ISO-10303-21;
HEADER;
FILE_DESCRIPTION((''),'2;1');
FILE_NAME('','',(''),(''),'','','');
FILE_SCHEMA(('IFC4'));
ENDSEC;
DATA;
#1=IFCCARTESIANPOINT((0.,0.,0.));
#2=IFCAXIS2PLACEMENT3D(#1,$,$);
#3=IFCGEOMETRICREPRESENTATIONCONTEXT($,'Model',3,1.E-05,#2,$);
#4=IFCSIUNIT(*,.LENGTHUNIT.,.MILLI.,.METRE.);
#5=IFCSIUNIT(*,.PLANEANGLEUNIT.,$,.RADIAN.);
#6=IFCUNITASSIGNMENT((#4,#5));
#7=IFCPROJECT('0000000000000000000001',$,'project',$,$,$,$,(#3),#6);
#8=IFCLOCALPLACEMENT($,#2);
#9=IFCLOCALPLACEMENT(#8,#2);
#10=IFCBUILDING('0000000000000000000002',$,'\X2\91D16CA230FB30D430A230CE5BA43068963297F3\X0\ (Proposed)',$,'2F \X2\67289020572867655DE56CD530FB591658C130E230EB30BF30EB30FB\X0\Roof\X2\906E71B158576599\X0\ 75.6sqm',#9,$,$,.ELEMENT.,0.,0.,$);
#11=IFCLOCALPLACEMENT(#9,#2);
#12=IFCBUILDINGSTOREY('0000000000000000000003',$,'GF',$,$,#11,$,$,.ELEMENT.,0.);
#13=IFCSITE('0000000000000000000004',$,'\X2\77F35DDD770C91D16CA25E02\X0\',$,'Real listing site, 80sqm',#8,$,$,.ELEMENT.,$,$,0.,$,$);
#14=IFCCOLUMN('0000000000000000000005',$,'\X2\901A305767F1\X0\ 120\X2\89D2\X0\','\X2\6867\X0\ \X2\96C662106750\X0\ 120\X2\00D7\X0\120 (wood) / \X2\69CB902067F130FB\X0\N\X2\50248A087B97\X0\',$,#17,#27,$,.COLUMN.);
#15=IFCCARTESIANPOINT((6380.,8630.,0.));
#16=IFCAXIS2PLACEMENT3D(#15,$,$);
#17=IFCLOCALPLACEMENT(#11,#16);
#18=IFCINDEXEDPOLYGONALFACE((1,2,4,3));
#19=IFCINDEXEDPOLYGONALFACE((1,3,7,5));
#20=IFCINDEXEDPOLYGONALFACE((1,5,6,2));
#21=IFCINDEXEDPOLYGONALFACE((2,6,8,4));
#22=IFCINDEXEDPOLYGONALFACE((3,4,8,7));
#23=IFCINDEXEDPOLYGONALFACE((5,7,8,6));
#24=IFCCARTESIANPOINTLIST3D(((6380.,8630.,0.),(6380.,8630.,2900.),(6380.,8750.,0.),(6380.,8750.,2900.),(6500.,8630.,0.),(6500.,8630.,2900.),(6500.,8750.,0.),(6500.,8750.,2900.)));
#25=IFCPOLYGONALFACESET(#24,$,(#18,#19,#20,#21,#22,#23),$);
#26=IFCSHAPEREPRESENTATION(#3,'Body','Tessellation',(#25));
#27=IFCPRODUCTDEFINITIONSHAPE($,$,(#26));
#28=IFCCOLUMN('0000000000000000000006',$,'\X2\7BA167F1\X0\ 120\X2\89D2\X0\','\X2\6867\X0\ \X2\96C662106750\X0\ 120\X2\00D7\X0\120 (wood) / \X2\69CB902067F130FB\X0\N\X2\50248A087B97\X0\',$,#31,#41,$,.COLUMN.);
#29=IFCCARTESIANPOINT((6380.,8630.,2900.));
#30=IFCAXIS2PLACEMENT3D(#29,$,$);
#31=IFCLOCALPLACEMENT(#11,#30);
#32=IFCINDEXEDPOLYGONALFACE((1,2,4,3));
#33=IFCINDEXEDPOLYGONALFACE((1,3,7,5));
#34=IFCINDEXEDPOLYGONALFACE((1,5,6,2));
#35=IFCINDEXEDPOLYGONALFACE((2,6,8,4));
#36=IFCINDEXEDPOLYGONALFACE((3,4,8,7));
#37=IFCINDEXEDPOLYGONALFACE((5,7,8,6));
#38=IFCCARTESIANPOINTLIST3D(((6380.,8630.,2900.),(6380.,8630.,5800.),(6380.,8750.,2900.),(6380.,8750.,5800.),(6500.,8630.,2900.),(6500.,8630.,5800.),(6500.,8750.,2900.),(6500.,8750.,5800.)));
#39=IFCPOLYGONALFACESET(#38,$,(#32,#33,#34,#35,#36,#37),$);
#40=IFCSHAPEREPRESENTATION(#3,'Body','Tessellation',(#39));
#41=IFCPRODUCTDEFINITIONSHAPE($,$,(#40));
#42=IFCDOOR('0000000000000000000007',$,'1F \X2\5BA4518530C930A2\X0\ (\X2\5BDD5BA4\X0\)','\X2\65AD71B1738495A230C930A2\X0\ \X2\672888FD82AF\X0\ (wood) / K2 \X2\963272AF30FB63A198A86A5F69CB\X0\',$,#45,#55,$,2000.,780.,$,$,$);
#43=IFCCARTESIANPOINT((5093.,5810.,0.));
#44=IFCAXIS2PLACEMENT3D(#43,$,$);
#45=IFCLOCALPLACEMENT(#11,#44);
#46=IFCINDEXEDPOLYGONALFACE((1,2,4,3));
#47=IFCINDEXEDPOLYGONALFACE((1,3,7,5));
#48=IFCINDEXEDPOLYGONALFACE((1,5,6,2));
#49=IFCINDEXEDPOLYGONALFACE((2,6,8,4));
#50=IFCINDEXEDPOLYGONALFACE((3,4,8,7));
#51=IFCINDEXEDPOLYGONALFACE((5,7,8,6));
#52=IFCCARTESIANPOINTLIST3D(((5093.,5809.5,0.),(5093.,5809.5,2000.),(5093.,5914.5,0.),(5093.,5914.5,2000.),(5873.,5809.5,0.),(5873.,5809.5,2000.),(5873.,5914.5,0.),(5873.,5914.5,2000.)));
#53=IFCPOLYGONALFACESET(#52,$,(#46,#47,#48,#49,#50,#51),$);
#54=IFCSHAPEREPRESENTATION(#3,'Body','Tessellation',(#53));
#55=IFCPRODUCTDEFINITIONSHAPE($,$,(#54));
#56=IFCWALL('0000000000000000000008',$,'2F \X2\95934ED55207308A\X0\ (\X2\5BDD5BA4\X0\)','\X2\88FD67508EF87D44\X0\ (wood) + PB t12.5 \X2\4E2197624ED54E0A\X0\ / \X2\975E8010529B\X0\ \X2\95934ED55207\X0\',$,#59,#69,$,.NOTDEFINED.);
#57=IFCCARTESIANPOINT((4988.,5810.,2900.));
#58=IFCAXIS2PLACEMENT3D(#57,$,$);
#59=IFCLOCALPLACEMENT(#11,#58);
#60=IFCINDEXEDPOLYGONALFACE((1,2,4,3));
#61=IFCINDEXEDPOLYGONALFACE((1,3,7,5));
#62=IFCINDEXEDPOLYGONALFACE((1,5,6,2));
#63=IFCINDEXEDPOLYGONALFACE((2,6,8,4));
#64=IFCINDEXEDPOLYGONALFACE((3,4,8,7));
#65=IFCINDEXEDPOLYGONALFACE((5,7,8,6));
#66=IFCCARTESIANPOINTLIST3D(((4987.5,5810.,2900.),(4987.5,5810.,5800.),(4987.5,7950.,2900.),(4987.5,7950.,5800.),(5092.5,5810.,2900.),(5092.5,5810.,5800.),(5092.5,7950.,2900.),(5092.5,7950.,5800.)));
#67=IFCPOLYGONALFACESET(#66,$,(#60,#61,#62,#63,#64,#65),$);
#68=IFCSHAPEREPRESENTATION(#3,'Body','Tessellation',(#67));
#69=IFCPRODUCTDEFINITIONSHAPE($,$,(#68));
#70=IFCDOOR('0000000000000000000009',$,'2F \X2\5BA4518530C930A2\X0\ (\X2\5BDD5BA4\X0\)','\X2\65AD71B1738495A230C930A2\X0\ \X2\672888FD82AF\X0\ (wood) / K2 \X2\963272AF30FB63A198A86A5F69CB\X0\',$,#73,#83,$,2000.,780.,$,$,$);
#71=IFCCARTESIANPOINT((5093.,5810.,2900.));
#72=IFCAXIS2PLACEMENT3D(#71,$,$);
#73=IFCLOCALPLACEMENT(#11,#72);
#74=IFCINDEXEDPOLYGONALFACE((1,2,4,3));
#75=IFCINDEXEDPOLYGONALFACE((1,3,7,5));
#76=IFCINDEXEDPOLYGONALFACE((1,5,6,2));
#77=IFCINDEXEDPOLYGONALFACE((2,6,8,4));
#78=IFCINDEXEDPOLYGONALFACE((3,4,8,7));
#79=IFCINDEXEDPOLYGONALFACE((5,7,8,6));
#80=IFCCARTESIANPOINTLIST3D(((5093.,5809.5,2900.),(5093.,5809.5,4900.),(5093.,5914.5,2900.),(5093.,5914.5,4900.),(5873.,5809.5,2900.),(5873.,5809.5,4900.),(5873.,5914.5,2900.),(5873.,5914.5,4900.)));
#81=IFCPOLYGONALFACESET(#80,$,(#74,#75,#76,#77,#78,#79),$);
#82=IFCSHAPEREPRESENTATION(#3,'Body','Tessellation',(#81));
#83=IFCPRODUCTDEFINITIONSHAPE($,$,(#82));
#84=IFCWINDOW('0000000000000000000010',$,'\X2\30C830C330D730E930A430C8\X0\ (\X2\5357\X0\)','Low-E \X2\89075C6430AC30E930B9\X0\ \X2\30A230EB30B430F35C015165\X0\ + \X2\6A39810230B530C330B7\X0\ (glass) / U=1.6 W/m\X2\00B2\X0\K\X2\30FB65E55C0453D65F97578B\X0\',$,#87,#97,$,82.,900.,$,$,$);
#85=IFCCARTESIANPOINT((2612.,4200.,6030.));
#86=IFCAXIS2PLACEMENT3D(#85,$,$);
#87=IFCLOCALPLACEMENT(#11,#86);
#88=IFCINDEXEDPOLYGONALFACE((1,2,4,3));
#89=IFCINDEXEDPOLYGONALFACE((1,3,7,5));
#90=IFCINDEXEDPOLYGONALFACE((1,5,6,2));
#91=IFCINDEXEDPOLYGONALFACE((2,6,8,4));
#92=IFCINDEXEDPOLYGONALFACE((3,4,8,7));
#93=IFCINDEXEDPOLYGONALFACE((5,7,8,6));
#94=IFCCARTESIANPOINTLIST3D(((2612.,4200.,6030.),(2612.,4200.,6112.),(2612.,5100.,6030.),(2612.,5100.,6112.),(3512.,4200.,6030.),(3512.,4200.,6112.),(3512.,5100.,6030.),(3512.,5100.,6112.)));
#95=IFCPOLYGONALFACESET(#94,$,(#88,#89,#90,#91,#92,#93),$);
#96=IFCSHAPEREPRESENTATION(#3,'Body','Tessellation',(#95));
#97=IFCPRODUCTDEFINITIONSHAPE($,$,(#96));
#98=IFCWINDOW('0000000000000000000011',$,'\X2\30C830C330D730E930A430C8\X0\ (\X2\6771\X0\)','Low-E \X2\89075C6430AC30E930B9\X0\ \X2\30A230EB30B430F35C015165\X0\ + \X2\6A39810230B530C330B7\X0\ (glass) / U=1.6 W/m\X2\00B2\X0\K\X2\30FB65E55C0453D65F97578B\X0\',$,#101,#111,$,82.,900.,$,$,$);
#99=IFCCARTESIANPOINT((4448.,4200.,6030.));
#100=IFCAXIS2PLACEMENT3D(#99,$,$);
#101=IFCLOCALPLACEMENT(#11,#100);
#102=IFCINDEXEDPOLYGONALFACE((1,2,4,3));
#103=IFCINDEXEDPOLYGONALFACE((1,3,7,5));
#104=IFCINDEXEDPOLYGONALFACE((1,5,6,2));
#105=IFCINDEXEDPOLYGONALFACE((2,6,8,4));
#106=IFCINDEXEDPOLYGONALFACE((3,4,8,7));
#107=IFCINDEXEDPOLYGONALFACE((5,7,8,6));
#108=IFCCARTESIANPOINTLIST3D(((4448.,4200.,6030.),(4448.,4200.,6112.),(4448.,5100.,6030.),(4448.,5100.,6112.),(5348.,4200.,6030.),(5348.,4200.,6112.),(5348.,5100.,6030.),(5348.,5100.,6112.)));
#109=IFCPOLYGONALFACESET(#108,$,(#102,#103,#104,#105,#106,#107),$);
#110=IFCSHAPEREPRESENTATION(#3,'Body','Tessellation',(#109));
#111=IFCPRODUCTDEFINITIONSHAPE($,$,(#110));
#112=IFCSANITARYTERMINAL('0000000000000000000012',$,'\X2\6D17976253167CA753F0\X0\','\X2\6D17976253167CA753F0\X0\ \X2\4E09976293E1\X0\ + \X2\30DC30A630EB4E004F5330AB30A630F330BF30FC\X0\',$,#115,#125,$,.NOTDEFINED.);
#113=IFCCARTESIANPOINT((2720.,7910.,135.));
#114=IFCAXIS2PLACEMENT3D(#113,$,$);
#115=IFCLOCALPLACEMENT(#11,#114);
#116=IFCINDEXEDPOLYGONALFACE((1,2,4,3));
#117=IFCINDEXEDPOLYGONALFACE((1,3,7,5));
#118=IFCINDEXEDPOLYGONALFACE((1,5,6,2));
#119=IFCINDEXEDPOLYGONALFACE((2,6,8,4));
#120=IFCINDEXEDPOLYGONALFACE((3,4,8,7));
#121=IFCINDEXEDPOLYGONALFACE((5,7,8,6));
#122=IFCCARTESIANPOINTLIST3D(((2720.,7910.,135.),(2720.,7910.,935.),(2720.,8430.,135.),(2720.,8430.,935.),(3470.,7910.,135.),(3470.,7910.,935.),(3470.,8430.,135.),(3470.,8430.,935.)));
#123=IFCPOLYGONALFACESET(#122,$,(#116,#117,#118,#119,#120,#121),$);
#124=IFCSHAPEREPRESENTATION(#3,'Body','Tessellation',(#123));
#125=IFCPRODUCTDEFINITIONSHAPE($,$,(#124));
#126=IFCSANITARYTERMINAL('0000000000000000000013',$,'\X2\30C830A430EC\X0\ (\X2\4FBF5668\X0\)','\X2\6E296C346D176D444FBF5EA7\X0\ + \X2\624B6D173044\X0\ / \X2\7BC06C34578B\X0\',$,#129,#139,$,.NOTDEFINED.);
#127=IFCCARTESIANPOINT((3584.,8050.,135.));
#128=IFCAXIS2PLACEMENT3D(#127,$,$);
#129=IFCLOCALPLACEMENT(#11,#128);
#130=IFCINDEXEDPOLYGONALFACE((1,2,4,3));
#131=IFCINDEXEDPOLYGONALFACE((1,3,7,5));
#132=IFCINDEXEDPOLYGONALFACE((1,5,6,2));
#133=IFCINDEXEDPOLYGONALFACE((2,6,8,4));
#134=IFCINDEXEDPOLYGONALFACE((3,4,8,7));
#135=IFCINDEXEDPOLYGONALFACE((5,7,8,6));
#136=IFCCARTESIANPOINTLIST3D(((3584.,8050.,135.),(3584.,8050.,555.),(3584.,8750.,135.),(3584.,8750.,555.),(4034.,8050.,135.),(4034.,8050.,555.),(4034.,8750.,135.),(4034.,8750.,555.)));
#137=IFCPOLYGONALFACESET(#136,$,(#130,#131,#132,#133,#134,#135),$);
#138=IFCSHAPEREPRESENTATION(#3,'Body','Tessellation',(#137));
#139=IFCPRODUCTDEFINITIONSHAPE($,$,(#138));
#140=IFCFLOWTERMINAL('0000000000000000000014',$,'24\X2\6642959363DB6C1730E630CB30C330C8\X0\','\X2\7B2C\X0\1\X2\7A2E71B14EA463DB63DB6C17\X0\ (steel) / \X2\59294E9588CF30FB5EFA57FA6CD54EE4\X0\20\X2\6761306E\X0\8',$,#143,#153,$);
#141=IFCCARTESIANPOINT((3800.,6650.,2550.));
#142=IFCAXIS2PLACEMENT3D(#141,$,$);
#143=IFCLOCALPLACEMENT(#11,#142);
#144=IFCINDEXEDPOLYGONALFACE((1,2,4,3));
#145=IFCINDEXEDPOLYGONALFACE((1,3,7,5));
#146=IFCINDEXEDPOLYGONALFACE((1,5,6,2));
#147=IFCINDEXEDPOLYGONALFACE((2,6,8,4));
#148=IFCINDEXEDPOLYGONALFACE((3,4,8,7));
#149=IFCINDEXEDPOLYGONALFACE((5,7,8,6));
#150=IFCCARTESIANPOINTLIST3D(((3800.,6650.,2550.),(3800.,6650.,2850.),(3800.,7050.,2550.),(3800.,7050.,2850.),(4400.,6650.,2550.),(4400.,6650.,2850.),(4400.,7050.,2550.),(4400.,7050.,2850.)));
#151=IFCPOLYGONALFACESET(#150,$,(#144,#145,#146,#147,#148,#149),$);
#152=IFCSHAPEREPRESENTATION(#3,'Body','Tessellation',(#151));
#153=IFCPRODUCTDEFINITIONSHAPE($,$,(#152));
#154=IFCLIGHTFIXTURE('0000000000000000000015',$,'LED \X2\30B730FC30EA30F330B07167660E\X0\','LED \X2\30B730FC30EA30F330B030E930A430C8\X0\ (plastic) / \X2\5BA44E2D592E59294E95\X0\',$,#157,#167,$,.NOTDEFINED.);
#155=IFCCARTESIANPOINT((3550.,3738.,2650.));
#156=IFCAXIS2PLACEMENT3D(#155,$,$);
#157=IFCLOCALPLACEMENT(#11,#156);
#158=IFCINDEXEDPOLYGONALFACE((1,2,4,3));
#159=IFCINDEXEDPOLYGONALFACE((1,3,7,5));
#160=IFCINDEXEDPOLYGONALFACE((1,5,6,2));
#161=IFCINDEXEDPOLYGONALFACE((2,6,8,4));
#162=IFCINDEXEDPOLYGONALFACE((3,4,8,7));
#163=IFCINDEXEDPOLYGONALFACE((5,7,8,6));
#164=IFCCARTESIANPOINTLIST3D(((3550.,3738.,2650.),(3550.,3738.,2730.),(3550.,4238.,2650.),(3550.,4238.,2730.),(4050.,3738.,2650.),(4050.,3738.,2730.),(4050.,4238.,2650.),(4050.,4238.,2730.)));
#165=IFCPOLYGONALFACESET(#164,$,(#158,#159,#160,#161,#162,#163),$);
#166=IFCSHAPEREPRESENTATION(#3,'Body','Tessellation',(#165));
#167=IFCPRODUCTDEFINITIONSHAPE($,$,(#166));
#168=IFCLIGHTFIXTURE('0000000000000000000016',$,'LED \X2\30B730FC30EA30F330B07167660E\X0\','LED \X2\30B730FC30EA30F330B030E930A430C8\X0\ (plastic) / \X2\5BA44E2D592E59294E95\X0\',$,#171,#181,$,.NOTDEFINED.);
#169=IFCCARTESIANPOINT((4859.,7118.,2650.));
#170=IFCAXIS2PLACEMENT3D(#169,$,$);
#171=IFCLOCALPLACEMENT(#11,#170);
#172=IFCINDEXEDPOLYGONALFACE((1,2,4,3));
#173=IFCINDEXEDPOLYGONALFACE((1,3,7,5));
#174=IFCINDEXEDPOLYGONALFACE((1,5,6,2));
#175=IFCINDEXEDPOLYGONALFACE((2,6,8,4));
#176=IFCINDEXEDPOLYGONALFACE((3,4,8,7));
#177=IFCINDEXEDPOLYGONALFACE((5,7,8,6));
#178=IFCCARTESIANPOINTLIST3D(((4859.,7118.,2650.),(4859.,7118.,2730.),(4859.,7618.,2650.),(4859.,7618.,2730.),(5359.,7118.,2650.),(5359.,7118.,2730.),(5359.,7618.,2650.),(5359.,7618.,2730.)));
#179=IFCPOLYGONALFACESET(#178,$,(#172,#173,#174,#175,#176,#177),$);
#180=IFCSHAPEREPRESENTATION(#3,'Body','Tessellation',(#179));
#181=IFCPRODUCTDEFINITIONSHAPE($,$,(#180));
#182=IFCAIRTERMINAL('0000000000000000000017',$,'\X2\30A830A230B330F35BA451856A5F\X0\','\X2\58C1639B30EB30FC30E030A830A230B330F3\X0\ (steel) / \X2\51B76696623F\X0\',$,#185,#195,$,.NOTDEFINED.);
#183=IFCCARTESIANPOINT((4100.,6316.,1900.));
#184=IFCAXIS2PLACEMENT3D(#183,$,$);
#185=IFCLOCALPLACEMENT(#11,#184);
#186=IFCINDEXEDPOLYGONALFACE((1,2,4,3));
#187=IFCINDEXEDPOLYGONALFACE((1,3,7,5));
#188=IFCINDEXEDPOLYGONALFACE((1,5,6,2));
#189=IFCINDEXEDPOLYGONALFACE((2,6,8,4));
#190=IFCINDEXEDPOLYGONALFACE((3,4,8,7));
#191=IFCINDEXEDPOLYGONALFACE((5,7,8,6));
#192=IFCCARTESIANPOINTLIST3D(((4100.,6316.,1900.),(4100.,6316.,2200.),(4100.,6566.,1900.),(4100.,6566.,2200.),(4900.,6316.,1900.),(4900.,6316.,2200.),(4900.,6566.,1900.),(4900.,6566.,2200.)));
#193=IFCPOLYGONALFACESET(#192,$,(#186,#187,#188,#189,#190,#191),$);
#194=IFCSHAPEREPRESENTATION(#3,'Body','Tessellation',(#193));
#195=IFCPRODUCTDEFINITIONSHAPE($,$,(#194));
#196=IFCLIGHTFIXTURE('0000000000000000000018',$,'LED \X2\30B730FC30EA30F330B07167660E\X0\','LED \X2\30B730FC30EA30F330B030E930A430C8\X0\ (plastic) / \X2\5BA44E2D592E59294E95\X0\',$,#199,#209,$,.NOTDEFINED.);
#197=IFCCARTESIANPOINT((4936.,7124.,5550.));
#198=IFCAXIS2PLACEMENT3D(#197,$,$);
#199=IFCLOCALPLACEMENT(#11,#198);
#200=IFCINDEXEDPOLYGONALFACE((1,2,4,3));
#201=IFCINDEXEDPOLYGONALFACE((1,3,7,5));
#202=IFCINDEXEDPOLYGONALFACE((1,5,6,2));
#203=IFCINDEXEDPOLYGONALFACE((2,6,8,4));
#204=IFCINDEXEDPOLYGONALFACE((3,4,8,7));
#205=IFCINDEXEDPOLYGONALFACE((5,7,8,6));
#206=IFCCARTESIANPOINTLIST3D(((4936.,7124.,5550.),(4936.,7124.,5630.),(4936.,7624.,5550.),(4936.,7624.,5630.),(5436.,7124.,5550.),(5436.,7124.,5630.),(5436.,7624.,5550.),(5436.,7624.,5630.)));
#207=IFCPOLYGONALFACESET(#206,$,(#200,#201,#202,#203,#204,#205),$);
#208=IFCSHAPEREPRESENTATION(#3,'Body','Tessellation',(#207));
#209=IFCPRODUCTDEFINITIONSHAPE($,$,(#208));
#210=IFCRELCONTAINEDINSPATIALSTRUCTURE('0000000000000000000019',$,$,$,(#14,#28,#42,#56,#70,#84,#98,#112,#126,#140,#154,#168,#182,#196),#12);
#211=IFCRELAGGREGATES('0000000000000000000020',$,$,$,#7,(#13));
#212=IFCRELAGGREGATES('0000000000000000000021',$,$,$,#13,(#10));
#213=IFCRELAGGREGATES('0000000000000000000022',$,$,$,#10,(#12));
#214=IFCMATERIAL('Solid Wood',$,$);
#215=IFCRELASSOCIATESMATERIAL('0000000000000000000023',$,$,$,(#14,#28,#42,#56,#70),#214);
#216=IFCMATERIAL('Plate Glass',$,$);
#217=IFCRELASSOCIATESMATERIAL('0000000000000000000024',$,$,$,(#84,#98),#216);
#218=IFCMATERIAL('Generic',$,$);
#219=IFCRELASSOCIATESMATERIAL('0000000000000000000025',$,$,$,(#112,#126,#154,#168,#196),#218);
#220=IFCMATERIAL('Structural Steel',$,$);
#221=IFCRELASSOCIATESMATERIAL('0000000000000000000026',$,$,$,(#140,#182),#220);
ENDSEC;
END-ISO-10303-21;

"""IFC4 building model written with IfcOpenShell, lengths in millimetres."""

from ifc_helpers import new_model, si_unit, frame, frame_2d, origin, place, context, project, spatial, rectangle, extrude, material, element, save


model = new_model("IFC4")

# Units and contexts
model_context = context("Model", 3, precision=1e-05, world=origin())
ifc_project = project(units=[si_unit("LENGTHUNIT", "METRE", prefix="MILLI"), si_unit("PLANEANGLEUNIT", "RADIAN")], contexts=[model_context])

# Site, building, storey
site_placement = place(None, origin())
site = spatial("IfcSite", under=ifc_project, at=site_placement, Name="石川県金沢市", ObjectType="Real listing site, 80sqm", CompositionType="ELEMENT", RefElevation=0.0)
building_placement = place(site_placement, origin())
building = spatial("IfcBuilding", under=site, at=building_placement, Name="金沢・ピアノ室と防音 (Proposed)", ObjectType="2F 木造在来工法・外壁モルタル・Roof遮熱塗料 75.6sqm", CompositionType="ELEMENT", ElevationOfRefHeight=0.0, ElevationOfTerrain=0.0)
storey_placement = place(building_placement, origin())
storey = spatial("IfcBuildingStorey", under=building, at=storey_placement, Name="GF", CompositionType="ELEMENT", Elevation=0.0)

# Columns
ifc_material_1 = material(Name="Solid Wood")
column_1_placement = place(storey_placement, frame((6380.0, 8630.0, 0.0)))
element("IfcColumn", 1, at=column_1_placement, inside=storey, material=ifc_material_1, Name="通し柱 120角", Description="桧 集成材 120×120 (wood) / 構造柱・N値計算", PredefinedType="COLUMN", context=model_context, shape_type="SweptSolid", body=[
    extrude(rectangle(XDim=120.0, YDim=120.0, at=frame_2d((60.0, 60.0))), frame((6380.0, 8630.0, 0.0)), (0.0, 0.0, 1.0), 2900.0),
])
column_2_placement = place(storey_placement, frame((6380.0, 8630.0, 2900.0)))
element("IfcColumn", 2, at=column_2_placement, inside=storey, material=ifc_material_1, Name="管柱 120角", Description="桧 集成材 120×120 (wood) / 構造柱・N値計算", PredefinedType="COLUMN", context=model_context, shape_type="SweptSolid", body=[
    extrude(rectangle(XDim=120.0, YDim=120.0, at=frame_2d((60.0, 60.0))), frame((6380.0, 8630.0, 2900.0)), (0.0, 0.0, 1.0), 2900.0),
])

# Door
door_1_placement = place(storey_placement, frame((5093.0, 5810.0, 0.0)))
element("IfcDoor", 3, at=door_1_placement, inside=storey, material=ifc_material_1, Name="1F 室内ドア (寝室)", Description="断熱玄関ドア 木製芯 (wood) / K2 防犯・採風機構", OverallHeight=2000.0, OverallWidth=780.0, context=model_context, shape_type="SweptSolid", body=[
    extrude(rectangle(XDim=780.0, YDim=105.0, at=frame_2d((390.0, 52.0))), frame((5093.0, 5810.0, 0.0)), (0.0, 0.0, 1.0), 2000.0),
])

# Wall
wall_1_placement = place(storey_placement, frame((4988.0, 5810.0, 2900.0)))
element("IfcWall", 4, at=wall_1_placement, inside=storey, material=ifc_material_1, Name="2F 間仕切り (寝室)", Description="製材軸組 (wood) + PB t12.5 両面仕上 / 非耐力 間仕切", PredefinedType="NOTDEFINED", context=model_context, shape_type="SweptSolid", body=[
    extrude(rectangle(XDim=105.0, YDim=2140.0, at=frame_2d((52.0, 1070.0))), frame((4988.0, 5810.0, 2900.0)), (0.0, 0.0, 1.0), 2900.0),
])

# Door
door_2_placement = place(storey_placement, frame((5093.0, 5810.0, 2900.0)))
element("IfcDoor", 5, at=door_2_placement, inside=storey, material=ifc_material_1, Name="2F 室内ドア (寝室)", Description="断熱玄関ドア 木製芯 (wood) / K2 防犯・採風機構", OverallHeight=2000.0, OverallWidth=780.0, context=model_context, shape_type="SweptSolid", body=[
    extrude(rectangle(XDim=780.0, YDim=105.0, at=frame_2d((390.0, 52.0))), frame((5093.0, 5810.0, 2900.0)), (0.0, 0.0, 1.0), 2000.0),
])

# Windows
ifc_material_2 = material(Name="Plate Glass")
window_1_placement = place(storey_placement, frame((2612.0, 4200.0, 6030.0)))
element("IfcWindow", 6, at=window_1_placement, inside=storey, material=ifc_material_2, Name="トップライト (南)", Description="Low-E 複層ガラス アルゴン封入 + 樹脂サッシ (glass) / U=1.6 W/m²K・日射取得型", OverallHeight=82.0, OverallWidth=900.0, context=model_context, shape_type="SweptSolid", body=[
    extrude(rectangle(XDim=900.0, YDim=900.0, at=frame_2d((450.0, 450.0))), frame((2612.0, 4200.0, 6030.0)), (0.0, 0.0, 1.0), 82.0),
])
window_2_placement = place(storey_placement, frame((4448.0, 4200.0, 6030.0)))
element("IfcWindow", 7, at=window_2_placement, inside=storey, material=ifc_material_2, Name="トップライト (東)", Description="Low-E 複層ガラス アルゴン封入 + 樹脂サッシ (glass) / U=1.6 W/m²K・日射取得型", OverallHeight=82.0, OverallWidth=900.0, context=model_context, shape_type="SweptSolid", body=[
    extrude(rectangle(XDim=900.0, YDim=900.0, at=frame_2d((450.0, 450.0))), frame((4448.0, 4200.0, 6030.0)), (0.0, 0.0, 1.0), 82.0),
])

# Sanitary terminals
ifc_material_3 = material(Name="Generic")
sanitary_terminal_1_placement = place(storey_placement, frame((2720.0, 7910.0, 135.0)))
element("IfcSanitaryTerminal", 8, at=sanitary_terminal_1_placement, inside=storey, material=ifc_material_3, Name="洗面化粧台", Description="洗面化粧台 三面鏡 + ボウル一体カウンター", PredefinedType="NOTDEFINED", context=model_context, shape_type="SweptSolid", body=[
    extrude(rectangle(XDim=750.0, YDim=520.0, at=frame_2d((375.0, 260.0))), frame((2720.0, 7910.0, 135.0)), (0.0, 0.0, 1.0), 800.0),
])
sanitary_terminal_2_placement = place(storey_placement, frame((3584.0, 8050.0, 135.0)))
element("IfcSanitaryTerminal", 9, at=sanitary_terminal_2_placement, inside=storey, material=ifc_material_3, Name="トイレ (便器)", Description="温水洗浄便座 + 手洗い / 節水型", PredefinedType="NOTDEFINED", context=model_context, shape_type="SweptSolid", body=[
    extrude(rectangle(XDim=450.0, YDim=700.0, at=frame_2d((225.0, 350.0))), frame((3584.0, 8050.0, 135.0)), (0.0, 0.0, 1.0), 420.0),
])

# Flow terminal
ifc_material_4 = material(Name="Structural Steel")
flow_terminal_placement = place(storey_placement, frame((3800.0, 6650.0, 2550.0)))
element("IfcFlowTerminal", 10, at=flow_terminal_placement, inside=storey, material=ifc_material_4, Name="24時間換気ユニット", Description="第1種熱交換換気 (steel) / 天井裏・建基法令20条の8", context=model_context, shape_type="SweptSolid", body=[
    extrude(rectangle(XDim=600.0, YDim=400.0, at=frame_2d((300.0, 200.0))), frame((3800.0, 6650.0, 2550.0)), (0.0, 0.0, 1.0), 300.0),
])

# Light fixtures
light_fixture_1_placement = place(storey_placement, frame((3550.0, 3738.0, 2650.0)))
element("IfcLightFixture", 11, at=light_fixture_1_placement, inside=storey, material=ifc_material_3, Name="LED シーリング照明", Description="LED シーリングライト (plastic) / 室中央天井", PredefinedType="NOTDEFINED", context=model_context, shape_type="SweptSolid", body=[
    extrude(rectangle(XDim=500.0, YDim=500.0, at=frame_2d((250.0, 250.0))), frame((3550.0, 3738.0, 2650.0)), (0.0, 0.0, 1.0), 80.0),
])
light_fixture_2_placement = place(storey_placement, frame((4859.0, 7118.0, 2650.0)))
element("IfcLightFixture", 12, at=light_fixture_2_placement, inside=storey, material=ifc_material_3, Name="LED シーリング照明", Description="LED シーリングライト (plastic) / 室中央天井", PredefinedType="NOTDEFINED", context=model_context, shape_type="SweptSolid", body=[
    extrude(rectangle(XDim=500.0, YDim=500.0, at=frame_2d((250.0, 250.0))), frame((4859.0, 7118.0, 2650.0)), (0.0, 0.0, 1.0), 80.0),
])

# Air terminal
air_terminal_placement = place(storey_placement, frame((4100.0, 6316.0, 1900.0)))
element("IfcAirTerminal", 13, at=air_terminal_placement, inside=storey, material=ifc_material_4, Name="エアコン室内機", Description="壁掛ルームエアコン (steel) / 冷暖房", PredefinedType="NOTDEFINED", context=model_context, shape_type="SweptSolid", body=[
    extrude(rectangle(XDim=800.0, YDim=250.0, at=frame_2d((400.0, 125.0))), frame((4100.0, 6316.0, 1900.0)), (0.0, 0.0, 1.0), 300.0),
])

# Light fixture
light_fixture_3_placement = place(storey_placement, frame((4936.0, 7124.0, 5550.0)))
element("IfcLightFixture", 14, at=light_fixture_3_placement, inside=storey, material=ifc_material_3, Name="LED シーリング照明", Description="LED シーリングライト (plastic) / 室中央天井", PredefinedType="NOTDEFINED", context=model_context, shape_type="SweptSolid", body=[
    extrude(rectangle(XDim=500.0, YDim=500.0, at=frame_2d((250.0, 250.0))), frame((4936.0, 7124.0, 5550.0)), (0.0, 0.0, 1.0), 80.0),
])

save(model, "model.ifc")
